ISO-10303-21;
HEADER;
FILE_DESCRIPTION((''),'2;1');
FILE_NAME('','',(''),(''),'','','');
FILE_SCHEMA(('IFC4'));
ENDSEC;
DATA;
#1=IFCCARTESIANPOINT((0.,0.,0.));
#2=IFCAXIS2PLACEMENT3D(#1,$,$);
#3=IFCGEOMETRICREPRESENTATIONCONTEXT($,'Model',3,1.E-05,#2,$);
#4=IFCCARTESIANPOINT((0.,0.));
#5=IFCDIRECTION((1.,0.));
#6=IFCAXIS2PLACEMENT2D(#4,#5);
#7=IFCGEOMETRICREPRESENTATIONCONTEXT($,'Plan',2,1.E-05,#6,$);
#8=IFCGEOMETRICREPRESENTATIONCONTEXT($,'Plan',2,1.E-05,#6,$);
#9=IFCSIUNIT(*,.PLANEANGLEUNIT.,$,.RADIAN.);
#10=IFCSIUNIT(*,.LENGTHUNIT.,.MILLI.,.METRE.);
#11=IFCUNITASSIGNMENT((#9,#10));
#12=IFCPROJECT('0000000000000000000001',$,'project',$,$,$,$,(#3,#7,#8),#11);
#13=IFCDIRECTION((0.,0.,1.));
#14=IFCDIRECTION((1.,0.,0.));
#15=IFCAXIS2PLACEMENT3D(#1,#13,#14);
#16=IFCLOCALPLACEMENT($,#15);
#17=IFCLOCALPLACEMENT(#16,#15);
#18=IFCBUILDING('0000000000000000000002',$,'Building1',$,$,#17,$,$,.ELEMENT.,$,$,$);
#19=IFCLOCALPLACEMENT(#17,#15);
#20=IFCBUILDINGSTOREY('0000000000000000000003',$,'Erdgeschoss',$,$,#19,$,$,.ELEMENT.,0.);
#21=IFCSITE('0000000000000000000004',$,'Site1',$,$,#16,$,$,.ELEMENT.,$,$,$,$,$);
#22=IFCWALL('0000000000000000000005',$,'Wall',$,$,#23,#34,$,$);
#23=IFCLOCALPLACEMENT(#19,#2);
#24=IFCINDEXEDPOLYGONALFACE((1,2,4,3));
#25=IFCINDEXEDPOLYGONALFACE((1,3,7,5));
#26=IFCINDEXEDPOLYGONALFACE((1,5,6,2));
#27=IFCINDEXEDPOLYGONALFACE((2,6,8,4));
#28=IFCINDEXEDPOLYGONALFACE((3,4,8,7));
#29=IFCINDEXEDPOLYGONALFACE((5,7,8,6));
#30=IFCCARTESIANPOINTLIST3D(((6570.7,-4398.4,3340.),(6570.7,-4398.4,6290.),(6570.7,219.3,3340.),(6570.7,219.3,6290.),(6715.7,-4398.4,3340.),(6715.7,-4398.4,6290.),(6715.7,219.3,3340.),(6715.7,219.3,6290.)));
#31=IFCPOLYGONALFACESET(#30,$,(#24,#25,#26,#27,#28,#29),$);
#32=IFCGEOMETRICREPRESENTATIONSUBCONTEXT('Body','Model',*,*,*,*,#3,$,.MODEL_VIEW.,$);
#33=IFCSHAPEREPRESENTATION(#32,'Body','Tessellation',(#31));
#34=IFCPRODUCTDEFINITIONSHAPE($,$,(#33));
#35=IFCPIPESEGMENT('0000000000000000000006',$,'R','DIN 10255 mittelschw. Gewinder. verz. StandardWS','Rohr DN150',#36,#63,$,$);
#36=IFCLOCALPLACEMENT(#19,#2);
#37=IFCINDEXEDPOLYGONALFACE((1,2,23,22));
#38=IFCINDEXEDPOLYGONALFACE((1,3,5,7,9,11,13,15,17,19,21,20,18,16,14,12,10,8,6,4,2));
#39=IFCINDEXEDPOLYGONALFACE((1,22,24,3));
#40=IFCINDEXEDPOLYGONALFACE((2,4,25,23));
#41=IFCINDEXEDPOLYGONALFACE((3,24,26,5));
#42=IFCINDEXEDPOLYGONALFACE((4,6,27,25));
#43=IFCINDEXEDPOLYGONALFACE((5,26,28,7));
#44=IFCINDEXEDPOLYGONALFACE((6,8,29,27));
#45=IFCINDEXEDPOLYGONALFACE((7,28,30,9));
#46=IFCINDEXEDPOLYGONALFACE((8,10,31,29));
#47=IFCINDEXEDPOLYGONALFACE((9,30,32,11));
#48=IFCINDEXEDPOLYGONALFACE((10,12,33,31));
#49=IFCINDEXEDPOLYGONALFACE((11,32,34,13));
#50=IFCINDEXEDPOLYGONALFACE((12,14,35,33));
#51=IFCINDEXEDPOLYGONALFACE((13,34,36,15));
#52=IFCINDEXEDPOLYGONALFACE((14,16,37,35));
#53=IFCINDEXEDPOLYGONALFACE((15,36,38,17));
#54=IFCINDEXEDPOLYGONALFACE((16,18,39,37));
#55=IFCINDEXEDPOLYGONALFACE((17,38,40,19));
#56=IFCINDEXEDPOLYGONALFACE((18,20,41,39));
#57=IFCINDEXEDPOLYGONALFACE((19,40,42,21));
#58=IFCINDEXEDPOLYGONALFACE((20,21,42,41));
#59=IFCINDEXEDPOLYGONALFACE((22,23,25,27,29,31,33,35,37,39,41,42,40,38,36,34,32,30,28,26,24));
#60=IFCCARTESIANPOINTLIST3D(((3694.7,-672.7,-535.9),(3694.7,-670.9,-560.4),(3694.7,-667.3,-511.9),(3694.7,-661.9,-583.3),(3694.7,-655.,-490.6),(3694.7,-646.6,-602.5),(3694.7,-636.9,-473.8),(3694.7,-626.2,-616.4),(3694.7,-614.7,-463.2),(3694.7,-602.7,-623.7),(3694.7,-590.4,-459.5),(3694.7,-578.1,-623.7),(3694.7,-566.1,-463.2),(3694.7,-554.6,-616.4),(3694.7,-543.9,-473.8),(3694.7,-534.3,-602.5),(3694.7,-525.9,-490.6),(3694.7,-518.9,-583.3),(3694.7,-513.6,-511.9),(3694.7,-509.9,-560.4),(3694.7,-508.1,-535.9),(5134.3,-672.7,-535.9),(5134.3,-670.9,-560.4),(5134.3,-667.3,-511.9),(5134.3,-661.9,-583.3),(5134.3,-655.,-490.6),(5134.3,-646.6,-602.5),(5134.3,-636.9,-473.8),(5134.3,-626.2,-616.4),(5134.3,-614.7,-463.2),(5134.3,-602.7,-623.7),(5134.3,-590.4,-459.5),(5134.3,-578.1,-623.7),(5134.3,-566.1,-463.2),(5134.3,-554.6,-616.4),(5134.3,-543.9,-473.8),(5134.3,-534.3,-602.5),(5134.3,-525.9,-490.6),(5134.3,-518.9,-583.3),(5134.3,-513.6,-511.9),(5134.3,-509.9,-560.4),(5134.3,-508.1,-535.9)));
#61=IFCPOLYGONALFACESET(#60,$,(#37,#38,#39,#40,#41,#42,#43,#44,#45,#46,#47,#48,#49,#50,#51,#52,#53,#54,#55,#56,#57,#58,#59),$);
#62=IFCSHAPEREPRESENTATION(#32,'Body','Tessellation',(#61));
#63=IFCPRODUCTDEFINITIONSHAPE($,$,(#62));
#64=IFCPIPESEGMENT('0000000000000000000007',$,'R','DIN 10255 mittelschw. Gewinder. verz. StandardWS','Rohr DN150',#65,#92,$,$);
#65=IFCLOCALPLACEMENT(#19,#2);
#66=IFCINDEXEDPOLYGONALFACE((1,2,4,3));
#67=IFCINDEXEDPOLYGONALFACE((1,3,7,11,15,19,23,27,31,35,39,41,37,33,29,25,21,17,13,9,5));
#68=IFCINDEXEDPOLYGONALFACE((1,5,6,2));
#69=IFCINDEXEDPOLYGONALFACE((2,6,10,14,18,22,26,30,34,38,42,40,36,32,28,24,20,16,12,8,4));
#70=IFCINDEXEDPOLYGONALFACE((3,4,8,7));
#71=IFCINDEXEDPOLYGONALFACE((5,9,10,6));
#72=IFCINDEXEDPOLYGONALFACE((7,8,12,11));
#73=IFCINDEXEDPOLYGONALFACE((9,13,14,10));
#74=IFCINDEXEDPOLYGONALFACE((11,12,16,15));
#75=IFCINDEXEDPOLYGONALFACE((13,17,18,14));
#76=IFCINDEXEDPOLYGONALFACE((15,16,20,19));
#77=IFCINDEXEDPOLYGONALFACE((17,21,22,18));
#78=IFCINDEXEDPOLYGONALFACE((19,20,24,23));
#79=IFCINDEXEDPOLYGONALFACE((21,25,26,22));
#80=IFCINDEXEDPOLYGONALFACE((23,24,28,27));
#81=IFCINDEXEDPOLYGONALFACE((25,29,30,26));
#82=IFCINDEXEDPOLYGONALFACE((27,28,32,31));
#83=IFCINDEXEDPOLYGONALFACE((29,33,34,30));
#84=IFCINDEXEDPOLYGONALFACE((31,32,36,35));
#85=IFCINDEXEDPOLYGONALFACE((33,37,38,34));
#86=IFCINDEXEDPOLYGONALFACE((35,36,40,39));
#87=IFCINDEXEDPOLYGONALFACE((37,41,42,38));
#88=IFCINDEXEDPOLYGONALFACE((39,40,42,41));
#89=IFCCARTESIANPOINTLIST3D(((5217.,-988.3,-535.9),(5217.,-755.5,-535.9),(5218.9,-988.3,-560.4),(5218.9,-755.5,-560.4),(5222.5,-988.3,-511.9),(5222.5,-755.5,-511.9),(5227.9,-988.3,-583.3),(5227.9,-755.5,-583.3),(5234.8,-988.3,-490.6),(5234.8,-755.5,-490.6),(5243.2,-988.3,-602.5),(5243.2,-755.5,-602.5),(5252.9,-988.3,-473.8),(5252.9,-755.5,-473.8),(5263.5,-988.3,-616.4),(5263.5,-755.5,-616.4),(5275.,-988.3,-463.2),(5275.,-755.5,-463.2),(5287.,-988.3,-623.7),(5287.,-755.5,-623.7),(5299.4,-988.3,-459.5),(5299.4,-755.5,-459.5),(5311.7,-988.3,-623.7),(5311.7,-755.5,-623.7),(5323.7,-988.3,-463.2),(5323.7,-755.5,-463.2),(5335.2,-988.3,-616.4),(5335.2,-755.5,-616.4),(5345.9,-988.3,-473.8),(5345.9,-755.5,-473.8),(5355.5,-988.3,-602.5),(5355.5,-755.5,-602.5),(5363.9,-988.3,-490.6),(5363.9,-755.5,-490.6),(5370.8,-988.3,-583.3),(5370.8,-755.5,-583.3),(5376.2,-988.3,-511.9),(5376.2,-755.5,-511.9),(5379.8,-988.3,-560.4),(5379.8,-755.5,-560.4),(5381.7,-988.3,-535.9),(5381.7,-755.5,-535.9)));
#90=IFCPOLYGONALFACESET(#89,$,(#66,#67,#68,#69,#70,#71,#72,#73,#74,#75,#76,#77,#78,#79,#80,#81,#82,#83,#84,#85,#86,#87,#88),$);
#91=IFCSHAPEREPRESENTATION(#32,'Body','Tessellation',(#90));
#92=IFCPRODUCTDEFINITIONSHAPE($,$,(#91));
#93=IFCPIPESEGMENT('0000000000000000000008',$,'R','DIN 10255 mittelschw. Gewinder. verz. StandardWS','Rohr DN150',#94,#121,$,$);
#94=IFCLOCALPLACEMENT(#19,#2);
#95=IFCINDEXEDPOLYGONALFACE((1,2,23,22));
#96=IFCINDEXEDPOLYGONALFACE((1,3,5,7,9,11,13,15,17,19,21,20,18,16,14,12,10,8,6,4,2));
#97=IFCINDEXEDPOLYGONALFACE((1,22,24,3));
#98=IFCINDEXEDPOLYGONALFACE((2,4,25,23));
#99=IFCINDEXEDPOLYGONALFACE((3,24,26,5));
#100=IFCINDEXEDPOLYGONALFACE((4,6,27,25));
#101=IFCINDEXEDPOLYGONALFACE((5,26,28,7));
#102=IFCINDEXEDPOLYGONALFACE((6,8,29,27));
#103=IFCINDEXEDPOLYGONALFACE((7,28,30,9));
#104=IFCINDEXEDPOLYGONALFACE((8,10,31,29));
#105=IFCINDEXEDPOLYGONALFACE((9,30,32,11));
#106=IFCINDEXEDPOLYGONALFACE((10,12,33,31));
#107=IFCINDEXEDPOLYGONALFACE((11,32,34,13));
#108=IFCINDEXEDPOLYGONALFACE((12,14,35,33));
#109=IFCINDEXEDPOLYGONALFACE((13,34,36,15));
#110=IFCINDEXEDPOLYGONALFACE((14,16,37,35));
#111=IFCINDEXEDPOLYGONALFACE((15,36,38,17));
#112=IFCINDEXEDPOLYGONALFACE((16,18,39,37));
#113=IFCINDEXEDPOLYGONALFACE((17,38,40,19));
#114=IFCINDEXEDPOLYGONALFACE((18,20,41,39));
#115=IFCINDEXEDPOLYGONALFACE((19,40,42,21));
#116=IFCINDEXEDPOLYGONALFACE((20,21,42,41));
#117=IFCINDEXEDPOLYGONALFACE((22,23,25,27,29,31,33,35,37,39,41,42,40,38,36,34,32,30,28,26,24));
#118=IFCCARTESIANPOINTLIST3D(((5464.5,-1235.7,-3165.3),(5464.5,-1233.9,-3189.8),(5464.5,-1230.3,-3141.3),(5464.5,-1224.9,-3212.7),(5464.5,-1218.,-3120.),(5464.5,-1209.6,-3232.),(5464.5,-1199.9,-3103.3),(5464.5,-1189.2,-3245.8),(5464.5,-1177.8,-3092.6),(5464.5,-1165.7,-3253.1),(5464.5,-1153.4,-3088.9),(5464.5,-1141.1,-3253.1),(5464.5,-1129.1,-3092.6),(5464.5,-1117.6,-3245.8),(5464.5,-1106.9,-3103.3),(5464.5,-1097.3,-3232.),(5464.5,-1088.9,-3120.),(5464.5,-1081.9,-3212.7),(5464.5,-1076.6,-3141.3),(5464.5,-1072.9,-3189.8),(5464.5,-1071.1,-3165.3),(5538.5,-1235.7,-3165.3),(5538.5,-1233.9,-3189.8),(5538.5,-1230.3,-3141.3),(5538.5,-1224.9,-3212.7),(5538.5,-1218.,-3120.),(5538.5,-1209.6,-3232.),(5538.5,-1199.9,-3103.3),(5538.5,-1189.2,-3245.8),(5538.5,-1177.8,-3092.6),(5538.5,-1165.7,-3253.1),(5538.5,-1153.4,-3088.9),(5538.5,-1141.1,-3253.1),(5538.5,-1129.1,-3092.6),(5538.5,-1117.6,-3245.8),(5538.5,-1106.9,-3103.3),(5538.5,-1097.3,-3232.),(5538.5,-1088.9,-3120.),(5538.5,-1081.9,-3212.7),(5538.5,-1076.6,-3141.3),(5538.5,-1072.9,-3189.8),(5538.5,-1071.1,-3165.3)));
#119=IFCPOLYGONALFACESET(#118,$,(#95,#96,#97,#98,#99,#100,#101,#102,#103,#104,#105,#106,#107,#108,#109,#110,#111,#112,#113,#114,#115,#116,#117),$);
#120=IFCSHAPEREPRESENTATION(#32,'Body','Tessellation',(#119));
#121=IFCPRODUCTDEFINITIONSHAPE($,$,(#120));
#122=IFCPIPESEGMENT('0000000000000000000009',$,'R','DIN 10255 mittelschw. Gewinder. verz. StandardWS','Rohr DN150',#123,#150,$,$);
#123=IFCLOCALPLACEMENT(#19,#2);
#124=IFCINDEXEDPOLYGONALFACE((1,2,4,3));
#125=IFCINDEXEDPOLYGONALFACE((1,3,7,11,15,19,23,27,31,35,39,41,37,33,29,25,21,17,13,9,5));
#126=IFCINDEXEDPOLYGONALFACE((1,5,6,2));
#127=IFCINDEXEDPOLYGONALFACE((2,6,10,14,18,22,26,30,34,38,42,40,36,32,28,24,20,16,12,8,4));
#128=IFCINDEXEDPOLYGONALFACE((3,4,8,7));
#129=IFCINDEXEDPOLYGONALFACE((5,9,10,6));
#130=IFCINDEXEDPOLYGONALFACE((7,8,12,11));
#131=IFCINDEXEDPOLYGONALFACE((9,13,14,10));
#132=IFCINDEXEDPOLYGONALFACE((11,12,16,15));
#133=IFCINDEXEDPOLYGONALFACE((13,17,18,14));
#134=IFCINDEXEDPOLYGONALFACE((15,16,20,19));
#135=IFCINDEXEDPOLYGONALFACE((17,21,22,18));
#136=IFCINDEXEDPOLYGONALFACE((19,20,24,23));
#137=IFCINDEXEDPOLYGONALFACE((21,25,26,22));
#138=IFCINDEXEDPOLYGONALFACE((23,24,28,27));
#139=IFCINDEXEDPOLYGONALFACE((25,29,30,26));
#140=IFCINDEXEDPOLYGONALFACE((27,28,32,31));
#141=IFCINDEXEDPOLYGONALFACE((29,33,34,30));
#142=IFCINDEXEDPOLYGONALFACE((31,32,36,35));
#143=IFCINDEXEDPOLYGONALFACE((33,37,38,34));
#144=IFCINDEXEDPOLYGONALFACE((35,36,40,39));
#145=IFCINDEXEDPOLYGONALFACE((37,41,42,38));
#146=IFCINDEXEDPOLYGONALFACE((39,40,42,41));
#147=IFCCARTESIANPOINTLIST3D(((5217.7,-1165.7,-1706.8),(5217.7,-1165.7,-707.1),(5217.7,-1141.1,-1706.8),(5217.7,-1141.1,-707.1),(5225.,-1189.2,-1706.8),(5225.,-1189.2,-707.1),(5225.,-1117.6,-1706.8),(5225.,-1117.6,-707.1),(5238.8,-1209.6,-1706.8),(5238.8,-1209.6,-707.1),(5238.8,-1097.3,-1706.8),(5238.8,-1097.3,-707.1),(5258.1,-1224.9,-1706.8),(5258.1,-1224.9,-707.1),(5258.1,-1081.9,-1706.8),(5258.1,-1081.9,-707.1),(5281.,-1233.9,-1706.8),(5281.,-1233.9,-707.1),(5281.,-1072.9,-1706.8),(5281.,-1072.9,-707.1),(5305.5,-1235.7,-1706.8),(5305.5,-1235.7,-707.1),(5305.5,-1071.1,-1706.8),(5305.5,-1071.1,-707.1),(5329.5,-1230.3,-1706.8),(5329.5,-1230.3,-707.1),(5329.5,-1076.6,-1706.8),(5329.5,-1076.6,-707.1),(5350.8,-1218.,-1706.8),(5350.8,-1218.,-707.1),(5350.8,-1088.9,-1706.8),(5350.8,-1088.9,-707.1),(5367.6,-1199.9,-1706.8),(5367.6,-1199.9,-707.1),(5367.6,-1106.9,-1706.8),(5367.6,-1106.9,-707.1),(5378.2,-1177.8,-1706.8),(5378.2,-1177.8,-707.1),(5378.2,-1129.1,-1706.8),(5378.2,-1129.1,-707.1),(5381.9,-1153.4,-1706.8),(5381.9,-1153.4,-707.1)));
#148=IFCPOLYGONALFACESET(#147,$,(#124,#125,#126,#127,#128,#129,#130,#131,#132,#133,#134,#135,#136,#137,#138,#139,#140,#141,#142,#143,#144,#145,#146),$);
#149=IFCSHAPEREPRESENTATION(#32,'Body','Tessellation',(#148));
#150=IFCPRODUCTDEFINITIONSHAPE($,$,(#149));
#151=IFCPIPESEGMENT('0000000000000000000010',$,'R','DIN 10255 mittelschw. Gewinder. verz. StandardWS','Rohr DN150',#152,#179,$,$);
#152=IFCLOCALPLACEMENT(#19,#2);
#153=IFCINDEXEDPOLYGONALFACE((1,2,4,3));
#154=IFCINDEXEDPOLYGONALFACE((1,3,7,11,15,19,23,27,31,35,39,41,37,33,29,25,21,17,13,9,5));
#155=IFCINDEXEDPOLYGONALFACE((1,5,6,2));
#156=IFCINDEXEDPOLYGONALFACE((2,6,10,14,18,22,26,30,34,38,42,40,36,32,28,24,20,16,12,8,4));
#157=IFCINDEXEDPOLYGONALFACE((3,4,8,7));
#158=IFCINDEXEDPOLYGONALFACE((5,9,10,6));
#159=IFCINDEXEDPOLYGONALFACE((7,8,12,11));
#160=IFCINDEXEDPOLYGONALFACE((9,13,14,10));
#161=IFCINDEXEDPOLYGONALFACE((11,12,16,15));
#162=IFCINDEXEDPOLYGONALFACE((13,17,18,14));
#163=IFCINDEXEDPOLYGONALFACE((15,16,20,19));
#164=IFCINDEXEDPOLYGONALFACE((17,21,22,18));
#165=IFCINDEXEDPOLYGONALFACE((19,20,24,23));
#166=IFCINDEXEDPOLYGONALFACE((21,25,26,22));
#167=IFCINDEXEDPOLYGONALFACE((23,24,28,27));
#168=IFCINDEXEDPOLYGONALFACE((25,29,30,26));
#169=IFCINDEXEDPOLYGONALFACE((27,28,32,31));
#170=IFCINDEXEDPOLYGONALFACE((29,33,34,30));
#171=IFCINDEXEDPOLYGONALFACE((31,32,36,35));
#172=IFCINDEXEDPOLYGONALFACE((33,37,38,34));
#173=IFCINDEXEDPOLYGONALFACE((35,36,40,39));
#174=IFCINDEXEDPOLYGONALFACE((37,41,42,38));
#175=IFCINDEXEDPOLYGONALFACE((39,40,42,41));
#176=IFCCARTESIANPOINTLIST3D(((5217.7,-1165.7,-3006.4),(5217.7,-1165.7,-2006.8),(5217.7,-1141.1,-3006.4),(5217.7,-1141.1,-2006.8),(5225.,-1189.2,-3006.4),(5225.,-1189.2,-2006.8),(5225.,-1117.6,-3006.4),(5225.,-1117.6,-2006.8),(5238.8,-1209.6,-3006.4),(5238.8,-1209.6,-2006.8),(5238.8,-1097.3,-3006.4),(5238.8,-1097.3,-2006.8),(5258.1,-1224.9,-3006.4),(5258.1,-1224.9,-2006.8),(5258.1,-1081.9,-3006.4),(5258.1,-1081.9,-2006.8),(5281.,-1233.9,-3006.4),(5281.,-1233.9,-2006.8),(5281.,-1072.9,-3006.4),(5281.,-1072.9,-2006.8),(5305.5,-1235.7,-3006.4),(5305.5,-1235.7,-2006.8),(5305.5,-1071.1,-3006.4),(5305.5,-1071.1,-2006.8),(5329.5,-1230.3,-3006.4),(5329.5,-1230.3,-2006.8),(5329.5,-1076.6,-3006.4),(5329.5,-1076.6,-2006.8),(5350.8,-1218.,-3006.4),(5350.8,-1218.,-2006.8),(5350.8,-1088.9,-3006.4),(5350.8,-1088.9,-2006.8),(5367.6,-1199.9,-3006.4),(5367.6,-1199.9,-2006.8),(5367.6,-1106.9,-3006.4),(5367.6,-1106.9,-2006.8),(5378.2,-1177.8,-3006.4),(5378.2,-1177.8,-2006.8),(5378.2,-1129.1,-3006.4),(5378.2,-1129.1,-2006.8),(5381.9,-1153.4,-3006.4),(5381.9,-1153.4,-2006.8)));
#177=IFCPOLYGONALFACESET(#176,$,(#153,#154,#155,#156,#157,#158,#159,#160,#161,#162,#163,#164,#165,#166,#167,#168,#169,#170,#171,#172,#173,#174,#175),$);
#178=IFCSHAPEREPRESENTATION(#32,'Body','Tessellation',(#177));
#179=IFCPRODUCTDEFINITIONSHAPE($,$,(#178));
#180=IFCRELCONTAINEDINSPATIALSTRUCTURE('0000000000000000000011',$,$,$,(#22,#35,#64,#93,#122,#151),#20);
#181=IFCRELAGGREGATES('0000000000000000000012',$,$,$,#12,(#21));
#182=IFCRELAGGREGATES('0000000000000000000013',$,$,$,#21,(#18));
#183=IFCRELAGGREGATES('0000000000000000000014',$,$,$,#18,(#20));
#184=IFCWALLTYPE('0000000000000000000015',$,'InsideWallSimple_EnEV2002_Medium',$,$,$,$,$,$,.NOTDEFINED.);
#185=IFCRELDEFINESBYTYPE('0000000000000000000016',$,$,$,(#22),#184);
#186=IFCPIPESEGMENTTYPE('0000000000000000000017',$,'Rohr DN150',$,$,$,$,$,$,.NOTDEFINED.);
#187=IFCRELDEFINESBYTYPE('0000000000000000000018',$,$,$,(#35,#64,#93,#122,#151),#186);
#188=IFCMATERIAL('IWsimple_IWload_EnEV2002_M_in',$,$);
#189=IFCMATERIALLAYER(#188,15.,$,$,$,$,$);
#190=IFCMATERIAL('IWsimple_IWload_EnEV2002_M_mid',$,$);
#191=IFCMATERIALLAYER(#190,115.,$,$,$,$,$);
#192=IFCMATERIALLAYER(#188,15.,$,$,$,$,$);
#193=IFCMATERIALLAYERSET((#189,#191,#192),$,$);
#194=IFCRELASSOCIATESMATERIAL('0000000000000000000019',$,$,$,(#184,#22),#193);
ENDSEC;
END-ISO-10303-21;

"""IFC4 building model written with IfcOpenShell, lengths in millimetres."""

from ifc_helpers import new_model, si_unit, frame, origin, origin_with_axes, origin_2d_with_axis, place, context, subcontext, project, spatial, indexed_curve, circle, outline, extrude, material, layer, layer_set, layer_usage, type_object, element, save


model = new_model("IFC4")

# Units and contexts
model_context = context("Model", 3, precision=1e-05, world=origin())
plan_context_1 = context("Plan", 2, precision=1e-05, world=origin_2d_with_axis())
plan_context_2 = context("Plan", 2, precision=1e-05, world=origin_2d_with_axis())
body_context = subcontext(model_context, "Body", "Model", "MODEL_VIEW")
ifc_project = project(units=[si_unit("PLANEANGLEUNIT", "RADIAN"), si_unit("LENGTHUNIT", "METRE", prefix="MILLI")], contexts=[model_context, plan_context_1, plan_context_2])

# Site, building, storey
site_placement = place(None, origin_with_axes())
site = spatial("IfcSite", under=ifc_project, at=site_placement, Name="Site1", CompositionType="ELEMENT")
building_placement = place(site_placement, origin_with_axes())
building = spatial("IfcBuilding", under=site, at=building_placement, Name="Building1", CompositionType="ELEMENT")
storey_placement = place(building_placement, origin_with_axes())
storey = spatial("IfcBuildingStorey", under=building, at=storey_placement, Name="Erdgeschoss", CompositionType="ELEMENT", Elevation=0.0)

# Wall
ifc_material_1 = material(Name="IWsimple_IWload_EnEV2002_M_in")
ifc_layer_1 = layer(ifc_material_1, 15.0)
ifc_material_2 = material(Name="IWsimple_IWload_EnEV2002_M_mid")
ifc_layer_2 = layer(ifc_material_2, 115.0)
ifc_layer_3 = layer(ifc_material_1, 15.0)
ifc_layer_set_1 = layer_set([ifc_layer_1, ifc_layer_2, ifc_layer_3])
ifc_layer_usage_1 = layer_usage(ifc_layer_set_1, "AXIS2", "POSITIVE", 0.0)
wall_type = type_object("IfcWallType", Name="InsideWallSimple_EnEV2002_Medium", PredefinedType="NOTDEFINED", material=ifc_layer_set_1)
wall_placement = place(storey_placement, frame((6570.7, 219.3, 3340.0), z_axis=(0.0, 0.0, 1.0), x_axis=(-0.000001, -1.0, 0.0)))
element("IfcWall", 1, at=wall_placement, inside=storey, type_object=wall_type, material=ifc_layer_usage_1, Name="Wall", context=body_context, shape_type="SweptSolid", body=[
    extrude(outline(indexed_curve([(0.0, 0.0), (0.0, 145.0), (4617.6, 145.0), (4617.6, 0.0), (0.0, 0.0)], self_intersect=False)), origin_with_axes(), (0.0, 0.0, 1.0), 2950.0),
])

# Pipe segments
pipe_segment_type_1 = type_object("IfcPipeSegmentType", Name="Rohr DN150", PredefinedType="NOTDEFINED")
pipe_segment_1_placement = place(storey_placement, frame((4414.5, -590.3, -542.0), z_axis=(0.0, 0.0, 1.0), x_axis=(1.0, 0.0, 0.0)))
element("IfcPipeSegment", 2, at=pipe_segment_1_placement, inside=storey, type_object=pipe_segment_type_1, Name="R", Description="DIN 10255 mittelschw. Gewinder. verz. StandardWS", ObjectType="Rohr DN150", context=body_context, shape_type="SolidModel", body=[
    extrude(circle(Radius=82.5, at=origin_2d_with_axis()), frame((-719.8, -0.2, 0.0), z_axis=(1.0, 0.0, 0.0), x_axis=(0.0, 0.0, 1.0)), (0.0, 0.0, 1.0), 1439.6),
])
pipe_segment_2_placement = place(storey_placement, frame((5299.5, -871.9, -542.0), z_axis=(0.0, 0.0, 1.0), x_axis=(1.0, 0.0, 0.0)))
element("IfcPipeSegment", 3, at=pipe_segment_2_placement, inside=storey, type_object=pipe_segment_type_1, Name="R", Description="DIN 10255 mittelschw. Gewinder. verz. StandardWS", ObjectType="Rohr DN150", context=body_context, shape_type="SolidModel", body=[
    extrude(circle(Radius=82.5, at=origin_2d_with_axis()), frame((-0.2, 116.4, 0.0), z_axis=(0.0, -1.0, 0.0), x_axis=(0.0, 0.0, 1.0)), (0.0, 0.0, 1.0), 232.8),
])
pipe_segment_3_placement = place(storey_placement, frame((5501.5, -1153.6, -3171.5), z_axis=(0.0, 0.0, 1.0), x_axis=(1.0, 0.0, 0.0)))
element("IfcPipeSegment", 4, at=pipe_segment_3_placement, inside=storey, type_object=pipe_segment_type_1, Name="R", Description="DIN 10255 mittelschw. Gewinder. verz. StandardWS", ObjectType="Rohr DN150", context=body_context, shape_type="SolidModel", body=[
    extrude(circle(Radius=82.5, at=origin_2d_with_axis()), frame((37.0, 0.1, 0.0), z_axis=(-1.0, 0.0, 0.0), x_axis=(0.0, 0.0, 1.0)), (0.0, 0.0, 1.0), 74.0),
])
for number, where, z_axis, x_axis, name in (
    (5, (5299.4, -1153.3, -1206.9), (0.0, 0.0, 1.0), (1.0, 0.0, 0.0), "R"),
    (6, (5299.4, -1153.3, -2506.6), (0.0, 0.0, 1.0), (1.0, 0.0, 0.0), "R"),
):
    element("IfcPipeSegment", number, at=place(storey_placement, frame(where, z_axis=z_axis, x_axis=x_axis)), inside=storey, type_object=pipe_segment_type_1, Name=name, Description="DIN 10255 mittelschw. Gewinder. verz. StandardWS", ObjectType="Rohr DN150", context=body_context, shape_type="SolidModel", body=[
        extrude(circle(Radius=82.5, at=origin_2d_with_axis()), frame((0.0, -0.1, 499.8), z_axis=(0.0, 0.0, -1.0), x_axis=(1.0, 0.0, 0.0)), (0.0, 0.0, 1.0), 999.6),
    ])

save(model, "model.ifc")
